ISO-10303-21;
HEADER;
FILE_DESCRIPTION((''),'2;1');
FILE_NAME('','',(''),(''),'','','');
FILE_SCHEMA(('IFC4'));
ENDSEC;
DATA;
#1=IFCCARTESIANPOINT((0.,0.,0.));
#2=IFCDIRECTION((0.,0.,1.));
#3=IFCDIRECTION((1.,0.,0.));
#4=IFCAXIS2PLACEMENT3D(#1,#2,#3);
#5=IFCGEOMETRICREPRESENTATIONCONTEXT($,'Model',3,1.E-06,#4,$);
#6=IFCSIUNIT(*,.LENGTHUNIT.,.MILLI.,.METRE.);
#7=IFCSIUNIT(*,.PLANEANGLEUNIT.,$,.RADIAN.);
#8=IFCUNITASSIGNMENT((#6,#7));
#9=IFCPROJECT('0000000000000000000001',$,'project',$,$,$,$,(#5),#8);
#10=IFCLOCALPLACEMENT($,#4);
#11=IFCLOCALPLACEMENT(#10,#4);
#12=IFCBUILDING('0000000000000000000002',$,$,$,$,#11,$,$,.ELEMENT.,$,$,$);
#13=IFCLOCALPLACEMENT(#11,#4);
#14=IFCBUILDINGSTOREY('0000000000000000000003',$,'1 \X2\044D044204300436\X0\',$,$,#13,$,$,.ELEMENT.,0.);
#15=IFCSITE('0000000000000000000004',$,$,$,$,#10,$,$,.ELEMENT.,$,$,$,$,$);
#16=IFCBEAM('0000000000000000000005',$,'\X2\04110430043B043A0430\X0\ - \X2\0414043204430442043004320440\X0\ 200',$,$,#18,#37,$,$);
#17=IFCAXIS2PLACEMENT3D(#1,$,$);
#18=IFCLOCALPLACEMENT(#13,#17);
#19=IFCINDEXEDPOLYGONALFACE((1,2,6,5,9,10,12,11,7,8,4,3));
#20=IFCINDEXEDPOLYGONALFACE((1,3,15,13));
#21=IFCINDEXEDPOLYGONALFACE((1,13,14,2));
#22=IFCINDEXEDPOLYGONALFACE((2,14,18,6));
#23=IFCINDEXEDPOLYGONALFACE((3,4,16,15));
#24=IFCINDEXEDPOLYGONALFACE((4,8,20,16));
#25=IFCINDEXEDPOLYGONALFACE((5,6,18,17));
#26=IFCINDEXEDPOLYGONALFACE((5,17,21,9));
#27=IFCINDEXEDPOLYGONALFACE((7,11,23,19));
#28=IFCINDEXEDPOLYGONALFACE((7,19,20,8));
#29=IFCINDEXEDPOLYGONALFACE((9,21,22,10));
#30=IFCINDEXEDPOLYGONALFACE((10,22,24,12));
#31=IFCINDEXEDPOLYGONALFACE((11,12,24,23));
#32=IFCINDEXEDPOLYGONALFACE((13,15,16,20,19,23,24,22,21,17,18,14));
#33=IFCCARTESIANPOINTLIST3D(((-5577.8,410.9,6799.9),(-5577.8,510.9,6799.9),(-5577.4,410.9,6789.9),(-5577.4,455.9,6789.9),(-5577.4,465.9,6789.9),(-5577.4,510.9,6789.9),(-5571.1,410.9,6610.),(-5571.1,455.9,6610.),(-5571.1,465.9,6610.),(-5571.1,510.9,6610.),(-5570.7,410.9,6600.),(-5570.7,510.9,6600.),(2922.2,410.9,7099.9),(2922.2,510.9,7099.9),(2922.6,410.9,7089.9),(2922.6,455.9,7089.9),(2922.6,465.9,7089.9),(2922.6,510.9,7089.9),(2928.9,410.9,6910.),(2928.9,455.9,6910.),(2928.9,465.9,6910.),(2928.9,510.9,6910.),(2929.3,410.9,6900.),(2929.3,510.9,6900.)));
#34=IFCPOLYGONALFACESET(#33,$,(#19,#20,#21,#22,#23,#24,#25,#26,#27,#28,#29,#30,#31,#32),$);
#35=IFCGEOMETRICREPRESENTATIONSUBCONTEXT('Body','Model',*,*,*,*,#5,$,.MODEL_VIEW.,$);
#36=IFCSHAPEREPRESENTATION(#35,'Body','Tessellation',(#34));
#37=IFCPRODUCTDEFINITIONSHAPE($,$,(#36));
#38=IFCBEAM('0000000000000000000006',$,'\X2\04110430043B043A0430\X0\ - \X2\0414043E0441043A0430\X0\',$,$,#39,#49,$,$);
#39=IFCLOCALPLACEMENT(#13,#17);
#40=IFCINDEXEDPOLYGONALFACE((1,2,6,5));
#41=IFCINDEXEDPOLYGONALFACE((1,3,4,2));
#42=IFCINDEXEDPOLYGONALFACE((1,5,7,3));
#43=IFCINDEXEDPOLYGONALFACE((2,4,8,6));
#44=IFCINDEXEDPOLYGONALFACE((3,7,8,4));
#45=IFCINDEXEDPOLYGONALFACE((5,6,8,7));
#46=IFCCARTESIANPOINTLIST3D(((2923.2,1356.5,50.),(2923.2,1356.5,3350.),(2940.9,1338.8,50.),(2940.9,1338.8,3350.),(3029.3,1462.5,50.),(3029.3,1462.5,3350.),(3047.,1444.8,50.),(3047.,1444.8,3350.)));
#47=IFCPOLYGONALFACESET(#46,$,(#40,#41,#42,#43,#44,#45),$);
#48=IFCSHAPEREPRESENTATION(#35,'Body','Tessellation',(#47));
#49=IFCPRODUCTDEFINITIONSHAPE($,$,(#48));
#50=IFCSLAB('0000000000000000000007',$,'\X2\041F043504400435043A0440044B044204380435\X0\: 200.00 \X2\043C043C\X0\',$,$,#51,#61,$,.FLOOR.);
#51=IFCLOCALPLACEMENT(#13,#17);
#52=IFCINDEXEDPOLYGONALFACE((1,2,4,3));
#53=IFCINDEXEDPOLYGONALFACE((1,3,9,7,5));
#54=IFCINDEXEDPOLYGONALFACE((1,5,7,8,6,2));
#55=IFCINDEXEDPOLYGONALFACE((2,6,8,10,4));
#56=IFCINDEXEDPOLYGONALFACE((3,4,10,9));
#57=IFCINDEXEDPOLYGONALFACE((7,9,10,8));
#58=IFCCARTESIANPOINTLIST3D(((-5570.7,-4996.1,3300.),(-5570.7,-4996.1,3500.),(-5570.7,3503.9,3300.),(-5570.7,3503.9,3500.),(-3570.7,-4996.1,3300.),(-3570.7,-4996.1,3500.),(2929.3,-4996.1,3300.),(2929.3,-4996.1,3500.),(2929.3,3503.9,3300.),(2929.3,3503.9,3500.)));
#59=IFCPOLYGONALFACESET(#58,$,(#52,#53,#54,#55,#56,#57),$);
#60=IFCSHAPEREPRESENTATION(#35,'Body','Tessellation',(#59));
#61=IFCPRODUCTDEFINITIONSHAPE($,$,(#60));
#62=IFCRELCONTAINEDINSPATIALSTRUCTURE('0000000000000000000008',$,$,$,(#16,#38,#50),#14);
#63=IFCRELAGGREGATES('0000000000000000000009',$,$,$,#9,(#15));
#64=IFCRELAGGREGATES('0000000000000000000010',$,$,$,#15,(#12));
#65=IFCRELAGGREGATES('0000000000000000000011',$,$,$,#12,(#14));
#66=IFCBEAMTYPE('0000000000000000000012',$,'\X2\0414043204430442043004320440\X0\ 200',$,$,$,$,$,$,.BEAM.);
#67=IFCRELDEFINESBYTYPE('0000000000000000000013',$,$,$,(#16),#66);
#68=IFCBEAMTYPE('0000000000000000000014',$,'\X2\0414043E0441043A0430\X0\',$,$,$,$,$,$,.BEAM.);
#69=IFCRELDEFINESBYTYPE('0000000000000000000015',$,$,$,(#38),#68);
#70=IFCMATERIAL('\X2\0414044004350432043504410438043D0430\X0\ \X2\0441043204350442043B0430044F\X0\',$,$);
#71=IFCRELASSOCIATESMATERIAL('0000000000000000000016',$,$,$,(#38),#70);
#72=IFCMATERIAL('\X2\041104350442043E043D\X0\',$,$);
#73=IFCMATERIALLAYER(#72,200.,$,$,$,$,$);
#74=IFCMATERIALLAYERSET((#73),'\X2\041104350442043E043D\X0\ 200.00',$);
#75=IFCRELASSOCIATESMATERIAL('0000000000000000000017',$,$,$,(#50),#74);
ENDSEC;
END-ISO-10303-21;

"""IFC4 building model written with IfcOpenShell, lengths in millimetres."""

from ifc_helpers import new_model, si_unit, frame, origin_with_axes, place, context, subcontext, project, spatial, line, indexed_curve, outline, extrude, source, transform, mapped, material, layer, layer_set, layer_usage, type_object, element, save


model = new_model("IFC4")

# Units and contexts
model_context = context("Model", 3, precision=1e-06, world=origin_with_axes())
body_context = subcontext(model_context, "Body", "Model", "MODEL_VIEW")
ifc_project = project(units=[si_unit("LENGTHUNIT", "METRE", prefix="MILLI"), si_unit("PLANEANGLEUNIT", "RADIAN")], contexts=[model_context])

# Site, building, storey
site_placement = place(None, origin_with_axes())
site = spatial("IfcSite", under=ifc_project, at=site_placement, CompositionType="ELEMENT")
building_placement = place(site_placement, origin_with_axes())
building = spatial("IfcBuilding", under=site, at=building_placement, CompositionType="ELEMENT")
storey_placement = place(building_placement, origin_with_axes())
storey = spatial("IfcBuildingStorey", under=building, at=storey_placement, Name="1 этаж", CompositionType="ELEMENT", Elevation=0.0)

# Beams
beam_type_1 = type_object("IfcBeamType", Name="Двутавр 200", PredefinedType="BEAM")
shared_shape_1 = source(origin_with_axes(), body_context, "Body", "SweptSolid", [
    extrude(outline(indexed_curve([(-50.0, 0.0), (50.0, 0.0), (50.0, 10.0), (5.0, 10.0), (5.0, 190.0), (50.0, 190.0), (50.0, 200.0), (-50.0, 200.0), (-50.0, 190.0), (-5.0, 190.0), (-5.0, 10.0), (-50.0, 10.0)], segments=[line(1, 2), line(2, 3), line(3, 4), line(4, 5), line(5, 6), line(6, 7), line(7, 8), line(8, 9), line(9, 10), line(10, 11), line(11, 12), line(12, 1)])), origin_with_axes(), (0.0, 0.0, -1.0), 8505.3),
])
beam_1_placement = place(storey_placement, frame((2929.3, 460.9, 6900.0), z_axis=(0.999378, 0.0, 0.035272), x_axis=(0.0, 1.0, 0.0)))
element("IfcBeam", 1, at=beam_1_placement, inside=storey, type_object=beam_type_1, Name="Балка - Двутавр 200", context=body_context, shape_type="MappedRepresentation", body=[
    mapped(shared_shape_1, transform((0.0, 0.0, 0.0), x_axis=(1.0, 0.0, 0.0), y_axis=(0.0, 1.0, 0.0), z_axis=(0.0, 0.0, 1.0), scale=1.0)),
])
ifc_material_1 = material(Name="Древесина светлая")
beam_type_2 = type_object("IfcBeamType", Name="Доска", PredefinedType="BEAM")
shared_shape_2 = source(origin_with_axes(), body_context, "Body", "SweptSolid", [
    extrude(outline(indexed_curve([(0.0, 0.0), (150.0, 0.0), (150.0, 25.0), (0.0, 25.0)], segments=[line(1, 2), line(2, 3), line(3, 4), line(4, 1)])), origin_with_axes(), (0.0, 0.0, -1.0), 3300.0),
])
beam_2_placement = place(storey_placement, frame((2923.2, 1356.5, 50.0), z_axis=(0.0, 0.0, -1.0), x_axis=(0.707107, 0.707107, 0.0)))
element("IfcBeam", 2, at=beam_2_placement, inside=storey, type_object=beam_type_2, material=ifc_material_1, Name="Балка - Доска", context=body_context, shape_type="MappedRepresentation", body=[
    mapped(shared_shape_2, transform((0.0, 0.0, 0.0), x_axis=(1.0, 0.0, 0.0), y_axis=(0.0, 1.0, 0.0), z_axis=(0.0, 0.0, 1.0), scale=1.0)),
])

# Slab
ifc_material_2 = material(Name="Бетон")
ifc_layer = layer(ifc_material_2, 200.0)
ifc_layer_set = layer_set([ifc_layer], Name="Бетон 200.00")
ifc_layer_usage = layer_usage(ifc_layer_set, "AXIS3", "NEGATIVE", -200.0)
slab_placement = place(storey_placement, frame((2929.3, 3503.9, 3300.0), z_axis=(0.0, 0.0, 1.0), x_axis=(-1.0, 0.0, 0.0)))
element("IfcSlab", 3, at=slab_placement, inside=storey, material=ifc_layer_usage, Name="Перекрытие: 200.00 мм", PredefinedType="FLOOR", context=body_context, shape_type="SweptSolid", body=[
    extrude(outline(indexed_curve([(0.0, 0.0), (8500.0, 0.0), (8500.0, 8500.0), (6500.0, 8500.0), (0.0, 8500.0)], segments=[line(1, 2), line(2, 3), line(3, 4), line(4, 5), line(5, 1)])), origin_with_axes(), (0.0, 0.0, 1.0), 200.0),
])

save(model, "model.ifc")
